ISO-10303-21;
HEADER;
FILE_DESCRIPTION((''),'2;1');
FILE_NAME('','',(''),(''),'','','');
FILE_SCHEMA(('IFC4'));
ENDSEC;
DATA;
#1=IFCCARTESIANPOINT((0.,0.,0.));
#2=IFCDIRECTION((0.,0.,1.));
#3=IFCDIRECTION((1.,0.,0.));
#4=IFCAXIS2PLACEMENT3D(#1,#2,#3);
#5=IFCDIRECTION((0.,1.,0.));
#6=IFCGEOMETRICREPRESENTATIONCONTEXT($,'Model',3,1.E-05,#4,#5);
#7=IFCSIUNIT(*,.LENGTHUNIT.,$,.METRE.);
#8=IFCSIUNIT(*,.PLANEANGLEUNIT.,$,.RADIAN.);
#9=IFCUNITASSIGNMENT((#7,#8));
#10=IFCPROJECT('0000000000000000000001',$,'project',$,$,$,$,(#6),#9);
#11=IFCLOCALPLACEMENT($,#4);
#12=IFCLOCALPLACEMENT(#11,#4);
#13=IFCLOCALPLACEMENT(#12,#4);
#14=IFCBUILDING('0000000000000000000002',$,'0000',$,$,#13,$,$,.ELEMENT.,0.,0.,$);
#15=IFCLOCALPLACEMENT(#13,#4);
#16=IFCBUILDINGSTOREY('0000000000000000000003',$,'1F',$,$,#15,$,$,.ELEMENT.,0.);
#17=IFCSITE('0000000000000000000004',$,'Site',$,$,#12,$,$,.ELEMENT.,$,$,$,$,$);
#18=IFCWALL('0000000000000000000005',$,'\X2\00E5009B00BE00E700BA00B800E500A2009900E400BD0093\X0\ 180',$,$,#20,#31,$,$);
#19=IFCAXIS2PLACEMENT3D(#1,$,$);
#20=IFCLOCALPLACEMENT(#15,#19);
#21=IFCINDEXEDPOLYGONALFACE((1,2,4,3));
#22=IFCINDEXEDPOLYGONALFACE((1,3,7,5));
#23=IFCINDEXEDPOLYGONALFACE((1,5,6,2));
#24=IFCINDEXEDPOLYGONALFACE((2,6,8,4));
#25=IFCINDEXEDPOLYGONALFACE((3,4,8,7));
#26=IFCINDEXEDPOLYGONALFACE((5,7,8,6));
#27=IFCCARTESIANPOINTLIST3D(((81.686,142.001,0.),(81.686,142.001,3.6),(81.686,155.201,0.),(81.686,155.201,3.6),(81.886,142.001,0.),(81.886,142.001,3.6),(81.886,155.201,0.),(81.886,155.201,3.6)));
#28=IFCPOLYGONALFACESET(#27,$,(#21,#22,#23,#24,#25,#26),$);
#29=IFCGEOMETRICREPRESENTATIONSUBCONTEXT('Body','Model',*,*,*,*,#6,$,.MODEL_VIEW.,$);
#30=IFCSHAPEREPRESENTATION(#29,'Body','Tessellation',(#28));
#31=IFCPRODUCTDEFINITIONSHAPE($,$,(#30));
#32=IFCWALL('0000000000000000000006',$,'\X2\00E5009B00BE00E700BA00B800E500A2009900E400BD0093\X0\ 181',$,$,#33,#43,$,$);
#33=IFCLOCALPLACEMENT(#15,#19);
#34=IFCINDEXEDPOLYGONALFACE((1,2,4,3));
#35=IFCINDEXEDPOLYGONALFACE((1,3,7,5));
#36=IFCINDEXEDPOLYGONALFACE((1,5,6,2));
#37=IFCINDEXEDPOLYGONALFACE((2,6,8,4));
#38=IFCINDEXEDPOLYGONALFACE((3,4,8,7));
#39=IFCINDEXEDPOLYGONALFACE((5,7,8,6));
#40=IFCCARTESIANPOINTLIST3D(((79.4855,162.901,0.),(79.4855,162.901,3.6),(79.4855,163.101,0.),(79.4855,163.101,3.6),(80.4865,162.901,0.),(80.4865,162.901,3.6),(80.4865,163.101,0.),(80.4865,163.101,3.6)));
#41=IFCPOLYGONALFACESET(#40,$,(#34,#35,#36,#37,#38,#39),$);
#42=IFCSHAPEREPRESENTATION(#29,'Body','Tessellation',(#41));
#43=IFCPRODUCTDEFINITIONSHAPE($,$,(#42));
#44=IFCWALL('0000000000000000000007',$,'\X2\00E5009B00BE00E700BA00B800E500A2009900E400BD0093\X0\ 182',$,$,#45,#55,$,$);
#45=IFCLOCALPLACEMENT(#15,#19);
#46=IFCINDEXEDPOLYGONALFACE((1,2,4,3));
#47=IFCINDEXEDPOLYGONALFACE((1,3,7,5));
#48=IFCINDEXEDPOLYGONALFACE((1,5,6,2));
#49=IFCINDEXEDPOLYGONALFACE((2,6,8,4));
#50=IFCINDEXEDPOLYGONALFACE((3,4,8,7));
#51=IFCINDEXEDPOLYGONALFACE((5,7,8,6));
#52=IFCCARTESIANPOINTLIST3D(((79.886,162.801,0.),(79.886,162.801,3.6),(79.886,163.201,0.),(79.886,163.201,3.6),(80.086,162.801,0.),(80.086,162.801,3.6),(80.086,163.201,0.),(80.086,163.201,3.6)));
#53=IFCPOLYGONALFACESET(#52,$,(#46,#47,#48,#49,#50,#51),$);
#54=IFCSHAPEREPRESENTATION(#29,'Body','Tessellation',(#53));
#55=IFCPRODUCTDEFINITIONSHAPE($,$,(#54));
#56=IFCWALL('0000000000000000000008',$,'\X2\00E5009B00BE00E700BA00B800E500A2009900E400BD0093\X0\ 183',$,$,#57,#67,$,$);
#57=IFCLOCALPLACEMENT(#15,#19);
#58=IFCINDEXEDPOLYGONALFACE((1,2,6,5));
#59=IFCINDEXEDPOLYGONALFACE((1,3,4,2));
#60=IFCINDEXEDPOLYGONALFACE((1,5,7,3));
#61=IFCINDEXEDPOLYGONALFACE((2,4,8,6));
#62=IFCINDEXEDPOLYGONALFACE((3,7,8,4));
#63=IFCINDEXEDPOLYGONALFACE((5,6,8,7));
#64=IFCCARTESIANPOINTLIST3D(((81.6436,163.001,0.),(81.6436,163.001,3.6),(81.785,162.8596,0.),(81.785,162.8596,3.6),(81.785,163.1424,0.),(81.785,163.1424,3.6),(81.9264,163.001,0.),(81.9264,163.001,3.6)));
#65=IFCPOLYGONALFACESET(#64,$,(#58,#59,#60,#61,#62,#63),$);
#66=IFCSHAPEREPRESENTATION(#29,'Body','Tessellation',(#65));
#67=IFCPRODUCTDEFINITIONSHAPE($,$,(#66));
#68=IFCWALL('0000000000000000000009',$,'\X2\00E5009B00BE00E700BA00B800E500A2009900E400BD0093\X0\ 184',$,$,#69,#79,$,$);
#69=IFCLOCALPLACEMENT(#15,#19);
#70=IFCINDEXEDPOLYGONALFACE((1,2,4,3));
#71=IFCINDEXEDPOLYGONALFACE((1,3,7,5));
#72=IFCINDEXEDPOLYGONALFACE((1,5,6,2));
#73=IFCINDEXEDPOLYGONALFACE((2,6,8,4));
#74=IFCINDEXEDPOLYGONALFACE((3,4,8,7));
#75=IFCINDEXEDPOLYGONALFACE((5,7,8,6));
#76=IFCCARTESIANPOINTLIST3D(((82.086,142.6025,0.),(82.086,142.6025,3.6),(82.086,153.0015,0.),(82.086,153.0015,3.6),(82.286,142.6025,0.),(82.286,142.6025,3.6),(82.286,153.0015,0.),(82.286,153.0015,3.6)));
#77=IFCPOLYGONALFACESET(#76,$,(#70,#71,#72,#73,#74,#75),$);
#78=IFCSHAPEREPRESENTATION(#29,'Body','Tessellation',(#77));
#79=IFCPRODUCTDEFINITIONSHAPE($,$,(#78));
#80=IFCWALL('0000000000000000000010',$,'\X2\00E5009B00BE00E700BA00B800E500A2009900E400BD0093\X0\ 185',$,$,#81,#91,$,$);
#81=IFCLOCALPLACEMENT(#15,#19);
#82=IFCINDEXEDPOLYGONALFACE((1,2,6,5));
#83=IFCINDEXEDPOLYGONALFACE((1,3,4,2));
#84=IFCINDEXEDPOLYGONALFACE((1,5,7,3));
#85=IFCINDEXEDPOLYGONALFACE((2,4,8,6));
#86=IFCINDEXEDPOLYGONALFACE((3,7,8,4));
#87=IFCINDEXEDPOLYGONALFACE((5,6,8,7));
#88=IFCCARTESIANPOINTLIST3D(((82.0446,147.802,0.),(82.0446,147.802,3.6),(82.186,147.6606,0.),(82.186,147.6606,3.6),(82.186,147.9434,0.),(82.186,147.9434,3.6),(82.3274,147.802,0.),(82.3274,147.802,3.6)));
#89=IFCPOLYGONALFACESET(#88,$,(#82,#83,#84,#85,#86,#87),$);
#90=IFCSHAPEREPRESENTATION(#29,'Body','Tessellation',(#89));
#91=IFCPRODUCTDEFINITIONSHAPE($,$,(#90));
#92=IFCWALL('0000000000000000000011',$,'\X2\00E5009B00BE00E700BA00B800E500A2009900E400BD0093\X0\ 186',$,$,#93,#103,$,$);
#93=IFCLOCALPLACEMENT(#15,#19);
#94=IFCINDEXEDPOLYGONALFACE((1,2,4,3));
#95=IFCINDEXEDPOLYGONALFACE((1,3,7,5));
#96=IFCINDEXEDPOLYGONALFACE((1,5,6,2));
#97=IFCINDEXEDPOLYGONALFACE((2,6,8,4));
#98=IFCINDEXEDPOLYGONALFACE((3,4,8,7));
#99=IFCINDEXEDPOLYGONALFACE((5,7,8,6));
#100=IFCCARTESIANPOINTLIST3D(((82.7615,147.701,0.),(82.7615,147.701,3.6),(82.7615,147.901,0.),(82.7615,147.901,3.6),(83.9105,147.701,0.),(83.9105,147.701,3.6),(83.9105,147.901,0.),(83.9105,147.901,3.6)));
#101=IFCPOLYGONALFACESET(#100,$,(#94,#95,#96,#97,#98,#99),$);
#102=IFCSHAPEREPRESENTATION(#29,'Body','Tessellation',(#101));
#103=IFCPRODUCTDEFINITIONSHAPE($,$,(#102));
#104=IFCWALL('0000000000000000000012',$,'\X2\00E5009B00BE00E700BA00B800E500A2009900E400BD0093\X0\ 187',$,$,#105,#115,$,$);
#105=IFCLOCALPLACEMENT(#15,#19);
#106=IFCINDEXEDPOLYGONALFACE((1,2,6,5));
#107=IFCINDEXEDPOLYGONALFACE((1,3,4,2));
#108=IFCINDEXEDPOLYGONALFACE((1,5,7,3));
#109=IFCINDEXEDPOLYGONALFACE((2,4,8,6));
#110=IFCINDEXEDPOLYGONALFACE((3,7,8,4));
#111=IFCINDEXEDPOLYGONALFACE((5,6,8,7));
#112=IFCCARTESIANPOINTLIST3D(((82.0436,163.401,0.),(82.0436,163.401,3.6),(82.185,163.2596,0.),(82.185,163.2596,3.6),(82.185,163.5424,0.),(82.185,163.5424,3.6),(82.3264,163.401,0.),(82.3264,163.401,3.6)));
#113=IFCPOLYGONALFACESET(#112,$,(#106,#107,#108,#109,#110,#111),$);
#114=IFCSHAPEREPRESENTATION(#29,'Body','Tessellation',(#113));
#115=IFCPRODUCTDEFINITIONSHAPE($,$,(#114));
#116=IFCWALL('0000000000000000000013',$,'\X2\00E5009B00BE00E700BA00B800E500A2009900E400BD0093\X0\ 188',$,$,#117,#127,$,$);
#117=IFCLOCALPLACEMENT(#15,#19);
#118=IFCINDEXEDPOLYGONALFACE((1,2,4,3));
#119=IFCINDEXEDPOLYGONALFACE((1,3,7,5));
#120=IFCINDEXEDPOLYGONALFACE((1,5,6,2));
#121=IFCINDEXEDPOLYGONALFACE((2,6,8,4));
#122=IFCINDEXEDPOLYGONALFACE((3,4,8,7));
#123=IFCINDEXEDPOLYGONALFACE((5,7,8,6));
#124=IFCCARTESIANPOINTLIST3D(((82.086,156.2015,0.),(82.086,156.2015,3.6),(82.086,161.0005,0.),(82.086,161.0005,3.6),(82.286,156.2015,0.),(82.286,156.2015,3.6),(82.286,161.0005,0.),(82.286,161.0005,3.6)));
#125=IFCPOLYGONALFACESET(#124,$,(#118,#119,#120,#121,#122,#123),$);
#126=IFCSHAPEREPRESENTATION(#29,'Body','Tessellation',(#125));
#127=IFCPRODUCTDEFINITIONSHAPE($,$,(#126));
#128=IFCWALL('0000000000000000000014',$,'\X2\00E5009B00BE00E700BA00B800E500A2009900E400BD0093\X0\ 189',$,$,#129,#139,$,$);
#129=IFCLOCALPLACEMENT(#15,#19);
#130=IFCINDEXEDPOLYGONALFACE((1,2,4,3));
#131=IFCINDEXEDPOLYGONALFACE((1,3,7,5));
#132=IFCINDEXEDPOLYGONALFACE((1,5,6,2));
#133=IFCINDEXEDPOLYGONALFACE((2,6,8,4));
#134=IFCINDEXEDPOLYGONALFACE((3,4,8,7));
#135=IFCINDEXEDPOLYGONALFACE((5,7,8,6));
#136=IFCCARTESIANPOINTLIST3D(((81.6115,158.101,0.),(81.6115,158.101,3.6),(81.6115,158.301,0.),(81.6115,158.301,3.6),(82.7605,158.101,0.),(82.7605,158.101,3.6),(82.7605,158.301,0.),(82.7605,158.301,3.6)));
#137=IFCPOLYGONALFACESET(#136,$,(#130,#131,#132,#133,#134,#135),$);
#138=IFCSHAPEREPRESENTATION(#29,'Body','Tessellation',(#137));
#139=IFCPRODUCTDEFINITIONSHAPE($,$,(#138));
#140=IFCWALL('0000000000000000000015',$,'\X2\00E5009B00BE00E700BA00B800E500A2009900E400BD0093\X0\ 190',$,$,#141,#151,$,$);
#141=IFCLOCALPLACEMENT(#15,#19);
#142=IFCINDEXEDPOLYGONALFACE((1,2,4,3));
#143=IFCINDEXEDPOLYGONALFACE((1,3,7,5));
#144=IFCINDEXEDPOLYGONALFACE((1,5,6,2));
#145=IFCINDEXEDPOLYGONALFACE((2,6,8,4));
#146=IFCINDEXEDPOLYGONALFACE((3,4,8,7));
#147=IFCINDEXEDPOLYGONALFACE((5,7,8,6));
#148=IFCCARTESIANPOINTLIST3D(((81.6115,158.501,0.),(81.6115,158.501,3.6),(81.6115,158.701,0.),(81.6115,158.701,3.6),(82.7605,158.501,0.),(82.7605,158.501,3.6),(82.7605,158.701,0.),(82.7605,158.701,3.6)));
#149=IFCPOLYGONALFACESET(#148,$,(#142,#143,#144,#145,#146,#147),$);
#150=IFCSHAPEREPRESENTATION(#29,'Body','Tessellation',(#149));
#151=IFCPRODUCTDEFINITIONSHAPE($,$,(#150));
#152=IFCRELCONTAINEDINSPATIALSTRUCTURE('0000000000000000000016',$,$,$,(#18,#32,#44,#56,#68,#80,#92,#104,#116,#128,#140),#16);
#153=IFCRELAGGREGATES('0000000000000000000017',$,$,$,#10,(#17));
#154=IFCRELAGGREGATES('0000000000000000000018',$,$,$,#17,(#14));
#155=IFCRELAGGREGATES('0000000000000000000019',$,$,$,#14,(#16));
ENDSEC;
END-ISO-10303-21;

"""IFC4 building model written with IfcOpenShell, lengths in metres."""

from ifc_helpers import new_model, si_unit, direction, frame, frame_2d, origin_with_axes, place, context, subcontext, project, spatial, rectangle, extrude, element, save


model = new_model("IFC4")

# Units and contexts
model_context = context("Model", 3, precision=1e-05, world=origin_with_axes(), true_north=direction((0.0, 1.0, 0.0)))
body_context = subcontext(model_context, "Body", "Model", "MODEL_VIEW")
ifc_project = project(units=[si_unit("LENGTHUNIT", "METRE"), si_unit("PLANEANGLEUNIT", "RADIAN")], contexts=[model_context])

# Site, building, storey
placement = place(None, origin_with_axes())
site_placement = place(placement, origin_with_axes())
site = spatial("IfcSite", under=ifc_project, at=site_placement, Name="Site", CompositionType="ELEMENT")
building_placement = place(site_placement, origin_with_axes())
building = spatial("IfcBuilding", under=site, at=building_placement, Name="0000", CompositionType="ELEMENT", ElevationOfRefHeight=0.0, ElevationOfTerrain=0.0)
storey_placement = place(building_placement, origin_with_axes())
storey = spatial("IfcBuildingStorey", under=building, at=storey_placement, Name="1F", CompositionType="ELEMENT", Elevation=0.0)

# Walls
wall_1_placement = place(storey_placement, frame((81.786, 148.601, 0.0), z_axis=(0.0, 0.0, 1.0), x_axis=(0.0, 1.0, 0.0)))
element("IfcWall", 1, at=wall_1_placement, inside=storey, Name="å\u009b¾çº¸å¢\u0099ä½\u0093 180", context=body_context, shape_type="SweptSolid", body=[
    extrude(rectangle(XDim=13.2, YDim=0.2, at=frame_2d((0.0, 0.0), x_axis=(1.0, 0.0, 0.0))), frame((0.0, 0.0, 0.0), z_axis=(0.0, 0.0, 1.0)), (0.0, 0.0, 1.0), 3.6),
])
wall_2_placement = place(storey_placement, frame((79.986, 163.001, 0.0), z_axis=(0.0, 0.0, 1.0), x_axis=(1.0, 0.0, 0.0)))
element("IfcWall", 2, at=wall_2_placement, inside=storey, Name="å\u009b¾çº¸å¢\u0099ä½\u0093 181", context=body_context, shape_type="SweptSolid", body=[
    extrude(rectangle(XDim=1.001, YDim=0.2, at=frame_2d((0.0, 0.0), x_axis=(1.0, 0.0, 0.0))), frame((0.0, 0.0, 0.0), z_axis=(0.0, 0.0, 1.0)), (0.0, 0.0, 1.0), 3.6),
])
wall_3_placement = place(storey_placement, frame((79.986, 163.001, 0.0), z_axis=(0.0, 0.0, 1.0), x_axis=(0.0, 1.0, 0.0)))
element("IfcWall", 3, at=wall_3_placement, inside=storey, Name="å\u009b¾çº¸å¢\u0099ä½\u0093 182", context=body_context, shape_type="SweptSolid", body=[
    extrude(rectangle(XDim=0.4, YDim=0.2, at=frame_2d((0.0, 0.0), x_axis=(1.0, 0.0, 0.0))), frame((0.0, 0.0, 0.0), z_axis=(0.0, 0.0, 1.0)), (0.0, 0.0, 1.0), 3.6),
])
wall_4_placement = place(storey_placement, frame((81.785, 163.001, 0.0), z_axis=(0.0, 0.0, 1.0), x_axis=(0.707107, -0.707107, 0.0)))
element("IfcWall", 4, at=wall_4_placement, inside=storey, Name="å\u009b¾çº¸å¢\u0099ä½\u0093 183", context=body_context, shape_type="SweptSolid", body=[
    extrude(rectangle(XDim=0.2, YDim=0.2, at=frame_2d((0.0, 0.0), x_axis=(1.0, 0.0, 0.0))), frame((0.0, 0.0, 0.0), z_axis=(0.0, 0.0, 1.0)), (0.0, 0.0, 1.0), 3.6),
])
wall_5_placement = place(storey_placement, frame((82.186, 147.802, 0.0), z_axis=(0.0, 0.0, 1.0), x_axis=(0.0, 1.0, 0.0)))
element("IfcWall", 5, at=wall_5_placement, inside=storey, Name="å\u009b¾çº¸å¢\u0099ä½\u0093 184", context=body_context, shape_type="SweptSolid", body=[
    extrude(rectangle(XDim=10.399, YDim=0.2, at=frame_2d((0.0, 0.0), x_axis=(1.0, 0.0, 0.0))), frame((0.0, 0.0, 0.0), z_axis=(0.0, 0.0, 1.0)), (0.0, 0.0, 1.0), 3.6),
])
wall_6_placement = place(storey_placement, frame((82.186, 147.802, 0.0), z_axis=(0.0, 0.0, 1.0), x_axis=(0.707107, -0.707107, 0.0)))
element("IfcWall", 6, at=wall_6_placement, inside=storey, Name="å\u009b¾çº¸å¢\u0099ä½\u0093 185", context=body_context, shape_type="SweptSolid", body=[
    extrude(rectangle(XDim=0.2, YDim=0.2, at=frame_2d((0.0, 0.0), x_axis=(1.0, 0.0, 0.0))), frame((0.0, 0.0, 0.0), z_axis=(0.0, 0.0, 1.0)), (0.0, 0.0, 1.0), 3.6),
])
wall_7_placement = place(storey_placement, frame((83.336, 147.801, 0.0), z_axis=(0.0, 0.0, 1.0), x_axis=(-1.0, 0.0, 0.0)))
element("IfcWall", 7, at=wall_7_placement, inside=storey, Name="å\u009b¾çº¸å¢\u0099ä½\u0093 186", context=body_context, shape_type="SweptSolid", body=[
    extrude(rectangle(XDim=1.149, YDim=0.2, at=frame_2d((0.0, 0.0), x_axis=(1.0, 0.0, 0.0))), frame((0.0, 0.0, 0.0), z_axis=(0.0, 0.0, 1.0)), (0.0, 0.0, 1.0), 3.6),
])
wall_8_placement = place(storey_placement, frame((82.185, 163.401, 0.0), z_axis=(0.0, 0.0, 1.0), x_axis=(0.707107, -0.707107, 0.0)))
element("IfcWall", 8, at=wall_8_placement, inside=storey, Name="å\u009b¾çº¸å¢\u0099ä½\u0093 187", context=body_context, shape_type="SweptSolid", body=[
    extrude(rectangle(XDim=0.2, YDim=0.2, at=frame_2d((0.0, 0.0), x_axis=(1.0, 0.0, 0.0))), frame((0.0, 0.0, 0.0), z_axis=(0.0, 0.0, 1.0)), (0.0, 0.0, 1.0), 3.6),
])
wall_9_placement = place(storey_placement, frame((82.186, 158.601, 0.0), z_axis=(0.0, 0.0, 1.0), x_axis=(0.0, 1.0, 0.0)))
element("IfcWall", 9, at=wall_9_placement, inside=storey, Name="å\u009b¾çº¸å¢\u0099ä½\u0093 188", context=body_context, shape_type="SweptSolid", body=[
    extrude(rectangle(XDim=4.799, YDim=0.2, at=frame_2d((0.0, 0.0), x_axis=(1.0, 0.0, 0.0))), frame((0.0, 0.0, 0.0), z_axis=(0.0, 0.0, 1.0)), (0.0, 0.0, 1.0), 3.6),
])
for number, where, z_axis, x_axis, name in (
    (10, (82.186, 158.201, 0.0), (0.0, 0.0, 1.0), (1.0, 0.0, 0.0), "å\u009b¾çº¸å¢\u0099ä½\u0093 189"),
    (11, (82.186, 158.601, 0.0), (0.0, 0.0, 1.0), (1.0, 0.0, 0.0), "å\u009b¾çº¸å¢\u0099ä½\u0093 190"),
):
    element("IfcWall", number, at=place(storey_placement, frame(where, z_axis=z_axis, x_axis=x_axis)), inside=storey, Name=name, context=body_context, shape_type="SweptSolid", body=[
        extrude(rectangle(XDim=1.149, YDim=0.2, at=frame_2d((0.0, 0.0), x_axis=(1.0, 0.0, 0.0))), frame((0.0, 0.0, 0.0), z_axis=(0.0, 0.0, 1.0)), (0.0, 0.0, 1.0), 3.6),
    ])

save(model, "model.ifc")
